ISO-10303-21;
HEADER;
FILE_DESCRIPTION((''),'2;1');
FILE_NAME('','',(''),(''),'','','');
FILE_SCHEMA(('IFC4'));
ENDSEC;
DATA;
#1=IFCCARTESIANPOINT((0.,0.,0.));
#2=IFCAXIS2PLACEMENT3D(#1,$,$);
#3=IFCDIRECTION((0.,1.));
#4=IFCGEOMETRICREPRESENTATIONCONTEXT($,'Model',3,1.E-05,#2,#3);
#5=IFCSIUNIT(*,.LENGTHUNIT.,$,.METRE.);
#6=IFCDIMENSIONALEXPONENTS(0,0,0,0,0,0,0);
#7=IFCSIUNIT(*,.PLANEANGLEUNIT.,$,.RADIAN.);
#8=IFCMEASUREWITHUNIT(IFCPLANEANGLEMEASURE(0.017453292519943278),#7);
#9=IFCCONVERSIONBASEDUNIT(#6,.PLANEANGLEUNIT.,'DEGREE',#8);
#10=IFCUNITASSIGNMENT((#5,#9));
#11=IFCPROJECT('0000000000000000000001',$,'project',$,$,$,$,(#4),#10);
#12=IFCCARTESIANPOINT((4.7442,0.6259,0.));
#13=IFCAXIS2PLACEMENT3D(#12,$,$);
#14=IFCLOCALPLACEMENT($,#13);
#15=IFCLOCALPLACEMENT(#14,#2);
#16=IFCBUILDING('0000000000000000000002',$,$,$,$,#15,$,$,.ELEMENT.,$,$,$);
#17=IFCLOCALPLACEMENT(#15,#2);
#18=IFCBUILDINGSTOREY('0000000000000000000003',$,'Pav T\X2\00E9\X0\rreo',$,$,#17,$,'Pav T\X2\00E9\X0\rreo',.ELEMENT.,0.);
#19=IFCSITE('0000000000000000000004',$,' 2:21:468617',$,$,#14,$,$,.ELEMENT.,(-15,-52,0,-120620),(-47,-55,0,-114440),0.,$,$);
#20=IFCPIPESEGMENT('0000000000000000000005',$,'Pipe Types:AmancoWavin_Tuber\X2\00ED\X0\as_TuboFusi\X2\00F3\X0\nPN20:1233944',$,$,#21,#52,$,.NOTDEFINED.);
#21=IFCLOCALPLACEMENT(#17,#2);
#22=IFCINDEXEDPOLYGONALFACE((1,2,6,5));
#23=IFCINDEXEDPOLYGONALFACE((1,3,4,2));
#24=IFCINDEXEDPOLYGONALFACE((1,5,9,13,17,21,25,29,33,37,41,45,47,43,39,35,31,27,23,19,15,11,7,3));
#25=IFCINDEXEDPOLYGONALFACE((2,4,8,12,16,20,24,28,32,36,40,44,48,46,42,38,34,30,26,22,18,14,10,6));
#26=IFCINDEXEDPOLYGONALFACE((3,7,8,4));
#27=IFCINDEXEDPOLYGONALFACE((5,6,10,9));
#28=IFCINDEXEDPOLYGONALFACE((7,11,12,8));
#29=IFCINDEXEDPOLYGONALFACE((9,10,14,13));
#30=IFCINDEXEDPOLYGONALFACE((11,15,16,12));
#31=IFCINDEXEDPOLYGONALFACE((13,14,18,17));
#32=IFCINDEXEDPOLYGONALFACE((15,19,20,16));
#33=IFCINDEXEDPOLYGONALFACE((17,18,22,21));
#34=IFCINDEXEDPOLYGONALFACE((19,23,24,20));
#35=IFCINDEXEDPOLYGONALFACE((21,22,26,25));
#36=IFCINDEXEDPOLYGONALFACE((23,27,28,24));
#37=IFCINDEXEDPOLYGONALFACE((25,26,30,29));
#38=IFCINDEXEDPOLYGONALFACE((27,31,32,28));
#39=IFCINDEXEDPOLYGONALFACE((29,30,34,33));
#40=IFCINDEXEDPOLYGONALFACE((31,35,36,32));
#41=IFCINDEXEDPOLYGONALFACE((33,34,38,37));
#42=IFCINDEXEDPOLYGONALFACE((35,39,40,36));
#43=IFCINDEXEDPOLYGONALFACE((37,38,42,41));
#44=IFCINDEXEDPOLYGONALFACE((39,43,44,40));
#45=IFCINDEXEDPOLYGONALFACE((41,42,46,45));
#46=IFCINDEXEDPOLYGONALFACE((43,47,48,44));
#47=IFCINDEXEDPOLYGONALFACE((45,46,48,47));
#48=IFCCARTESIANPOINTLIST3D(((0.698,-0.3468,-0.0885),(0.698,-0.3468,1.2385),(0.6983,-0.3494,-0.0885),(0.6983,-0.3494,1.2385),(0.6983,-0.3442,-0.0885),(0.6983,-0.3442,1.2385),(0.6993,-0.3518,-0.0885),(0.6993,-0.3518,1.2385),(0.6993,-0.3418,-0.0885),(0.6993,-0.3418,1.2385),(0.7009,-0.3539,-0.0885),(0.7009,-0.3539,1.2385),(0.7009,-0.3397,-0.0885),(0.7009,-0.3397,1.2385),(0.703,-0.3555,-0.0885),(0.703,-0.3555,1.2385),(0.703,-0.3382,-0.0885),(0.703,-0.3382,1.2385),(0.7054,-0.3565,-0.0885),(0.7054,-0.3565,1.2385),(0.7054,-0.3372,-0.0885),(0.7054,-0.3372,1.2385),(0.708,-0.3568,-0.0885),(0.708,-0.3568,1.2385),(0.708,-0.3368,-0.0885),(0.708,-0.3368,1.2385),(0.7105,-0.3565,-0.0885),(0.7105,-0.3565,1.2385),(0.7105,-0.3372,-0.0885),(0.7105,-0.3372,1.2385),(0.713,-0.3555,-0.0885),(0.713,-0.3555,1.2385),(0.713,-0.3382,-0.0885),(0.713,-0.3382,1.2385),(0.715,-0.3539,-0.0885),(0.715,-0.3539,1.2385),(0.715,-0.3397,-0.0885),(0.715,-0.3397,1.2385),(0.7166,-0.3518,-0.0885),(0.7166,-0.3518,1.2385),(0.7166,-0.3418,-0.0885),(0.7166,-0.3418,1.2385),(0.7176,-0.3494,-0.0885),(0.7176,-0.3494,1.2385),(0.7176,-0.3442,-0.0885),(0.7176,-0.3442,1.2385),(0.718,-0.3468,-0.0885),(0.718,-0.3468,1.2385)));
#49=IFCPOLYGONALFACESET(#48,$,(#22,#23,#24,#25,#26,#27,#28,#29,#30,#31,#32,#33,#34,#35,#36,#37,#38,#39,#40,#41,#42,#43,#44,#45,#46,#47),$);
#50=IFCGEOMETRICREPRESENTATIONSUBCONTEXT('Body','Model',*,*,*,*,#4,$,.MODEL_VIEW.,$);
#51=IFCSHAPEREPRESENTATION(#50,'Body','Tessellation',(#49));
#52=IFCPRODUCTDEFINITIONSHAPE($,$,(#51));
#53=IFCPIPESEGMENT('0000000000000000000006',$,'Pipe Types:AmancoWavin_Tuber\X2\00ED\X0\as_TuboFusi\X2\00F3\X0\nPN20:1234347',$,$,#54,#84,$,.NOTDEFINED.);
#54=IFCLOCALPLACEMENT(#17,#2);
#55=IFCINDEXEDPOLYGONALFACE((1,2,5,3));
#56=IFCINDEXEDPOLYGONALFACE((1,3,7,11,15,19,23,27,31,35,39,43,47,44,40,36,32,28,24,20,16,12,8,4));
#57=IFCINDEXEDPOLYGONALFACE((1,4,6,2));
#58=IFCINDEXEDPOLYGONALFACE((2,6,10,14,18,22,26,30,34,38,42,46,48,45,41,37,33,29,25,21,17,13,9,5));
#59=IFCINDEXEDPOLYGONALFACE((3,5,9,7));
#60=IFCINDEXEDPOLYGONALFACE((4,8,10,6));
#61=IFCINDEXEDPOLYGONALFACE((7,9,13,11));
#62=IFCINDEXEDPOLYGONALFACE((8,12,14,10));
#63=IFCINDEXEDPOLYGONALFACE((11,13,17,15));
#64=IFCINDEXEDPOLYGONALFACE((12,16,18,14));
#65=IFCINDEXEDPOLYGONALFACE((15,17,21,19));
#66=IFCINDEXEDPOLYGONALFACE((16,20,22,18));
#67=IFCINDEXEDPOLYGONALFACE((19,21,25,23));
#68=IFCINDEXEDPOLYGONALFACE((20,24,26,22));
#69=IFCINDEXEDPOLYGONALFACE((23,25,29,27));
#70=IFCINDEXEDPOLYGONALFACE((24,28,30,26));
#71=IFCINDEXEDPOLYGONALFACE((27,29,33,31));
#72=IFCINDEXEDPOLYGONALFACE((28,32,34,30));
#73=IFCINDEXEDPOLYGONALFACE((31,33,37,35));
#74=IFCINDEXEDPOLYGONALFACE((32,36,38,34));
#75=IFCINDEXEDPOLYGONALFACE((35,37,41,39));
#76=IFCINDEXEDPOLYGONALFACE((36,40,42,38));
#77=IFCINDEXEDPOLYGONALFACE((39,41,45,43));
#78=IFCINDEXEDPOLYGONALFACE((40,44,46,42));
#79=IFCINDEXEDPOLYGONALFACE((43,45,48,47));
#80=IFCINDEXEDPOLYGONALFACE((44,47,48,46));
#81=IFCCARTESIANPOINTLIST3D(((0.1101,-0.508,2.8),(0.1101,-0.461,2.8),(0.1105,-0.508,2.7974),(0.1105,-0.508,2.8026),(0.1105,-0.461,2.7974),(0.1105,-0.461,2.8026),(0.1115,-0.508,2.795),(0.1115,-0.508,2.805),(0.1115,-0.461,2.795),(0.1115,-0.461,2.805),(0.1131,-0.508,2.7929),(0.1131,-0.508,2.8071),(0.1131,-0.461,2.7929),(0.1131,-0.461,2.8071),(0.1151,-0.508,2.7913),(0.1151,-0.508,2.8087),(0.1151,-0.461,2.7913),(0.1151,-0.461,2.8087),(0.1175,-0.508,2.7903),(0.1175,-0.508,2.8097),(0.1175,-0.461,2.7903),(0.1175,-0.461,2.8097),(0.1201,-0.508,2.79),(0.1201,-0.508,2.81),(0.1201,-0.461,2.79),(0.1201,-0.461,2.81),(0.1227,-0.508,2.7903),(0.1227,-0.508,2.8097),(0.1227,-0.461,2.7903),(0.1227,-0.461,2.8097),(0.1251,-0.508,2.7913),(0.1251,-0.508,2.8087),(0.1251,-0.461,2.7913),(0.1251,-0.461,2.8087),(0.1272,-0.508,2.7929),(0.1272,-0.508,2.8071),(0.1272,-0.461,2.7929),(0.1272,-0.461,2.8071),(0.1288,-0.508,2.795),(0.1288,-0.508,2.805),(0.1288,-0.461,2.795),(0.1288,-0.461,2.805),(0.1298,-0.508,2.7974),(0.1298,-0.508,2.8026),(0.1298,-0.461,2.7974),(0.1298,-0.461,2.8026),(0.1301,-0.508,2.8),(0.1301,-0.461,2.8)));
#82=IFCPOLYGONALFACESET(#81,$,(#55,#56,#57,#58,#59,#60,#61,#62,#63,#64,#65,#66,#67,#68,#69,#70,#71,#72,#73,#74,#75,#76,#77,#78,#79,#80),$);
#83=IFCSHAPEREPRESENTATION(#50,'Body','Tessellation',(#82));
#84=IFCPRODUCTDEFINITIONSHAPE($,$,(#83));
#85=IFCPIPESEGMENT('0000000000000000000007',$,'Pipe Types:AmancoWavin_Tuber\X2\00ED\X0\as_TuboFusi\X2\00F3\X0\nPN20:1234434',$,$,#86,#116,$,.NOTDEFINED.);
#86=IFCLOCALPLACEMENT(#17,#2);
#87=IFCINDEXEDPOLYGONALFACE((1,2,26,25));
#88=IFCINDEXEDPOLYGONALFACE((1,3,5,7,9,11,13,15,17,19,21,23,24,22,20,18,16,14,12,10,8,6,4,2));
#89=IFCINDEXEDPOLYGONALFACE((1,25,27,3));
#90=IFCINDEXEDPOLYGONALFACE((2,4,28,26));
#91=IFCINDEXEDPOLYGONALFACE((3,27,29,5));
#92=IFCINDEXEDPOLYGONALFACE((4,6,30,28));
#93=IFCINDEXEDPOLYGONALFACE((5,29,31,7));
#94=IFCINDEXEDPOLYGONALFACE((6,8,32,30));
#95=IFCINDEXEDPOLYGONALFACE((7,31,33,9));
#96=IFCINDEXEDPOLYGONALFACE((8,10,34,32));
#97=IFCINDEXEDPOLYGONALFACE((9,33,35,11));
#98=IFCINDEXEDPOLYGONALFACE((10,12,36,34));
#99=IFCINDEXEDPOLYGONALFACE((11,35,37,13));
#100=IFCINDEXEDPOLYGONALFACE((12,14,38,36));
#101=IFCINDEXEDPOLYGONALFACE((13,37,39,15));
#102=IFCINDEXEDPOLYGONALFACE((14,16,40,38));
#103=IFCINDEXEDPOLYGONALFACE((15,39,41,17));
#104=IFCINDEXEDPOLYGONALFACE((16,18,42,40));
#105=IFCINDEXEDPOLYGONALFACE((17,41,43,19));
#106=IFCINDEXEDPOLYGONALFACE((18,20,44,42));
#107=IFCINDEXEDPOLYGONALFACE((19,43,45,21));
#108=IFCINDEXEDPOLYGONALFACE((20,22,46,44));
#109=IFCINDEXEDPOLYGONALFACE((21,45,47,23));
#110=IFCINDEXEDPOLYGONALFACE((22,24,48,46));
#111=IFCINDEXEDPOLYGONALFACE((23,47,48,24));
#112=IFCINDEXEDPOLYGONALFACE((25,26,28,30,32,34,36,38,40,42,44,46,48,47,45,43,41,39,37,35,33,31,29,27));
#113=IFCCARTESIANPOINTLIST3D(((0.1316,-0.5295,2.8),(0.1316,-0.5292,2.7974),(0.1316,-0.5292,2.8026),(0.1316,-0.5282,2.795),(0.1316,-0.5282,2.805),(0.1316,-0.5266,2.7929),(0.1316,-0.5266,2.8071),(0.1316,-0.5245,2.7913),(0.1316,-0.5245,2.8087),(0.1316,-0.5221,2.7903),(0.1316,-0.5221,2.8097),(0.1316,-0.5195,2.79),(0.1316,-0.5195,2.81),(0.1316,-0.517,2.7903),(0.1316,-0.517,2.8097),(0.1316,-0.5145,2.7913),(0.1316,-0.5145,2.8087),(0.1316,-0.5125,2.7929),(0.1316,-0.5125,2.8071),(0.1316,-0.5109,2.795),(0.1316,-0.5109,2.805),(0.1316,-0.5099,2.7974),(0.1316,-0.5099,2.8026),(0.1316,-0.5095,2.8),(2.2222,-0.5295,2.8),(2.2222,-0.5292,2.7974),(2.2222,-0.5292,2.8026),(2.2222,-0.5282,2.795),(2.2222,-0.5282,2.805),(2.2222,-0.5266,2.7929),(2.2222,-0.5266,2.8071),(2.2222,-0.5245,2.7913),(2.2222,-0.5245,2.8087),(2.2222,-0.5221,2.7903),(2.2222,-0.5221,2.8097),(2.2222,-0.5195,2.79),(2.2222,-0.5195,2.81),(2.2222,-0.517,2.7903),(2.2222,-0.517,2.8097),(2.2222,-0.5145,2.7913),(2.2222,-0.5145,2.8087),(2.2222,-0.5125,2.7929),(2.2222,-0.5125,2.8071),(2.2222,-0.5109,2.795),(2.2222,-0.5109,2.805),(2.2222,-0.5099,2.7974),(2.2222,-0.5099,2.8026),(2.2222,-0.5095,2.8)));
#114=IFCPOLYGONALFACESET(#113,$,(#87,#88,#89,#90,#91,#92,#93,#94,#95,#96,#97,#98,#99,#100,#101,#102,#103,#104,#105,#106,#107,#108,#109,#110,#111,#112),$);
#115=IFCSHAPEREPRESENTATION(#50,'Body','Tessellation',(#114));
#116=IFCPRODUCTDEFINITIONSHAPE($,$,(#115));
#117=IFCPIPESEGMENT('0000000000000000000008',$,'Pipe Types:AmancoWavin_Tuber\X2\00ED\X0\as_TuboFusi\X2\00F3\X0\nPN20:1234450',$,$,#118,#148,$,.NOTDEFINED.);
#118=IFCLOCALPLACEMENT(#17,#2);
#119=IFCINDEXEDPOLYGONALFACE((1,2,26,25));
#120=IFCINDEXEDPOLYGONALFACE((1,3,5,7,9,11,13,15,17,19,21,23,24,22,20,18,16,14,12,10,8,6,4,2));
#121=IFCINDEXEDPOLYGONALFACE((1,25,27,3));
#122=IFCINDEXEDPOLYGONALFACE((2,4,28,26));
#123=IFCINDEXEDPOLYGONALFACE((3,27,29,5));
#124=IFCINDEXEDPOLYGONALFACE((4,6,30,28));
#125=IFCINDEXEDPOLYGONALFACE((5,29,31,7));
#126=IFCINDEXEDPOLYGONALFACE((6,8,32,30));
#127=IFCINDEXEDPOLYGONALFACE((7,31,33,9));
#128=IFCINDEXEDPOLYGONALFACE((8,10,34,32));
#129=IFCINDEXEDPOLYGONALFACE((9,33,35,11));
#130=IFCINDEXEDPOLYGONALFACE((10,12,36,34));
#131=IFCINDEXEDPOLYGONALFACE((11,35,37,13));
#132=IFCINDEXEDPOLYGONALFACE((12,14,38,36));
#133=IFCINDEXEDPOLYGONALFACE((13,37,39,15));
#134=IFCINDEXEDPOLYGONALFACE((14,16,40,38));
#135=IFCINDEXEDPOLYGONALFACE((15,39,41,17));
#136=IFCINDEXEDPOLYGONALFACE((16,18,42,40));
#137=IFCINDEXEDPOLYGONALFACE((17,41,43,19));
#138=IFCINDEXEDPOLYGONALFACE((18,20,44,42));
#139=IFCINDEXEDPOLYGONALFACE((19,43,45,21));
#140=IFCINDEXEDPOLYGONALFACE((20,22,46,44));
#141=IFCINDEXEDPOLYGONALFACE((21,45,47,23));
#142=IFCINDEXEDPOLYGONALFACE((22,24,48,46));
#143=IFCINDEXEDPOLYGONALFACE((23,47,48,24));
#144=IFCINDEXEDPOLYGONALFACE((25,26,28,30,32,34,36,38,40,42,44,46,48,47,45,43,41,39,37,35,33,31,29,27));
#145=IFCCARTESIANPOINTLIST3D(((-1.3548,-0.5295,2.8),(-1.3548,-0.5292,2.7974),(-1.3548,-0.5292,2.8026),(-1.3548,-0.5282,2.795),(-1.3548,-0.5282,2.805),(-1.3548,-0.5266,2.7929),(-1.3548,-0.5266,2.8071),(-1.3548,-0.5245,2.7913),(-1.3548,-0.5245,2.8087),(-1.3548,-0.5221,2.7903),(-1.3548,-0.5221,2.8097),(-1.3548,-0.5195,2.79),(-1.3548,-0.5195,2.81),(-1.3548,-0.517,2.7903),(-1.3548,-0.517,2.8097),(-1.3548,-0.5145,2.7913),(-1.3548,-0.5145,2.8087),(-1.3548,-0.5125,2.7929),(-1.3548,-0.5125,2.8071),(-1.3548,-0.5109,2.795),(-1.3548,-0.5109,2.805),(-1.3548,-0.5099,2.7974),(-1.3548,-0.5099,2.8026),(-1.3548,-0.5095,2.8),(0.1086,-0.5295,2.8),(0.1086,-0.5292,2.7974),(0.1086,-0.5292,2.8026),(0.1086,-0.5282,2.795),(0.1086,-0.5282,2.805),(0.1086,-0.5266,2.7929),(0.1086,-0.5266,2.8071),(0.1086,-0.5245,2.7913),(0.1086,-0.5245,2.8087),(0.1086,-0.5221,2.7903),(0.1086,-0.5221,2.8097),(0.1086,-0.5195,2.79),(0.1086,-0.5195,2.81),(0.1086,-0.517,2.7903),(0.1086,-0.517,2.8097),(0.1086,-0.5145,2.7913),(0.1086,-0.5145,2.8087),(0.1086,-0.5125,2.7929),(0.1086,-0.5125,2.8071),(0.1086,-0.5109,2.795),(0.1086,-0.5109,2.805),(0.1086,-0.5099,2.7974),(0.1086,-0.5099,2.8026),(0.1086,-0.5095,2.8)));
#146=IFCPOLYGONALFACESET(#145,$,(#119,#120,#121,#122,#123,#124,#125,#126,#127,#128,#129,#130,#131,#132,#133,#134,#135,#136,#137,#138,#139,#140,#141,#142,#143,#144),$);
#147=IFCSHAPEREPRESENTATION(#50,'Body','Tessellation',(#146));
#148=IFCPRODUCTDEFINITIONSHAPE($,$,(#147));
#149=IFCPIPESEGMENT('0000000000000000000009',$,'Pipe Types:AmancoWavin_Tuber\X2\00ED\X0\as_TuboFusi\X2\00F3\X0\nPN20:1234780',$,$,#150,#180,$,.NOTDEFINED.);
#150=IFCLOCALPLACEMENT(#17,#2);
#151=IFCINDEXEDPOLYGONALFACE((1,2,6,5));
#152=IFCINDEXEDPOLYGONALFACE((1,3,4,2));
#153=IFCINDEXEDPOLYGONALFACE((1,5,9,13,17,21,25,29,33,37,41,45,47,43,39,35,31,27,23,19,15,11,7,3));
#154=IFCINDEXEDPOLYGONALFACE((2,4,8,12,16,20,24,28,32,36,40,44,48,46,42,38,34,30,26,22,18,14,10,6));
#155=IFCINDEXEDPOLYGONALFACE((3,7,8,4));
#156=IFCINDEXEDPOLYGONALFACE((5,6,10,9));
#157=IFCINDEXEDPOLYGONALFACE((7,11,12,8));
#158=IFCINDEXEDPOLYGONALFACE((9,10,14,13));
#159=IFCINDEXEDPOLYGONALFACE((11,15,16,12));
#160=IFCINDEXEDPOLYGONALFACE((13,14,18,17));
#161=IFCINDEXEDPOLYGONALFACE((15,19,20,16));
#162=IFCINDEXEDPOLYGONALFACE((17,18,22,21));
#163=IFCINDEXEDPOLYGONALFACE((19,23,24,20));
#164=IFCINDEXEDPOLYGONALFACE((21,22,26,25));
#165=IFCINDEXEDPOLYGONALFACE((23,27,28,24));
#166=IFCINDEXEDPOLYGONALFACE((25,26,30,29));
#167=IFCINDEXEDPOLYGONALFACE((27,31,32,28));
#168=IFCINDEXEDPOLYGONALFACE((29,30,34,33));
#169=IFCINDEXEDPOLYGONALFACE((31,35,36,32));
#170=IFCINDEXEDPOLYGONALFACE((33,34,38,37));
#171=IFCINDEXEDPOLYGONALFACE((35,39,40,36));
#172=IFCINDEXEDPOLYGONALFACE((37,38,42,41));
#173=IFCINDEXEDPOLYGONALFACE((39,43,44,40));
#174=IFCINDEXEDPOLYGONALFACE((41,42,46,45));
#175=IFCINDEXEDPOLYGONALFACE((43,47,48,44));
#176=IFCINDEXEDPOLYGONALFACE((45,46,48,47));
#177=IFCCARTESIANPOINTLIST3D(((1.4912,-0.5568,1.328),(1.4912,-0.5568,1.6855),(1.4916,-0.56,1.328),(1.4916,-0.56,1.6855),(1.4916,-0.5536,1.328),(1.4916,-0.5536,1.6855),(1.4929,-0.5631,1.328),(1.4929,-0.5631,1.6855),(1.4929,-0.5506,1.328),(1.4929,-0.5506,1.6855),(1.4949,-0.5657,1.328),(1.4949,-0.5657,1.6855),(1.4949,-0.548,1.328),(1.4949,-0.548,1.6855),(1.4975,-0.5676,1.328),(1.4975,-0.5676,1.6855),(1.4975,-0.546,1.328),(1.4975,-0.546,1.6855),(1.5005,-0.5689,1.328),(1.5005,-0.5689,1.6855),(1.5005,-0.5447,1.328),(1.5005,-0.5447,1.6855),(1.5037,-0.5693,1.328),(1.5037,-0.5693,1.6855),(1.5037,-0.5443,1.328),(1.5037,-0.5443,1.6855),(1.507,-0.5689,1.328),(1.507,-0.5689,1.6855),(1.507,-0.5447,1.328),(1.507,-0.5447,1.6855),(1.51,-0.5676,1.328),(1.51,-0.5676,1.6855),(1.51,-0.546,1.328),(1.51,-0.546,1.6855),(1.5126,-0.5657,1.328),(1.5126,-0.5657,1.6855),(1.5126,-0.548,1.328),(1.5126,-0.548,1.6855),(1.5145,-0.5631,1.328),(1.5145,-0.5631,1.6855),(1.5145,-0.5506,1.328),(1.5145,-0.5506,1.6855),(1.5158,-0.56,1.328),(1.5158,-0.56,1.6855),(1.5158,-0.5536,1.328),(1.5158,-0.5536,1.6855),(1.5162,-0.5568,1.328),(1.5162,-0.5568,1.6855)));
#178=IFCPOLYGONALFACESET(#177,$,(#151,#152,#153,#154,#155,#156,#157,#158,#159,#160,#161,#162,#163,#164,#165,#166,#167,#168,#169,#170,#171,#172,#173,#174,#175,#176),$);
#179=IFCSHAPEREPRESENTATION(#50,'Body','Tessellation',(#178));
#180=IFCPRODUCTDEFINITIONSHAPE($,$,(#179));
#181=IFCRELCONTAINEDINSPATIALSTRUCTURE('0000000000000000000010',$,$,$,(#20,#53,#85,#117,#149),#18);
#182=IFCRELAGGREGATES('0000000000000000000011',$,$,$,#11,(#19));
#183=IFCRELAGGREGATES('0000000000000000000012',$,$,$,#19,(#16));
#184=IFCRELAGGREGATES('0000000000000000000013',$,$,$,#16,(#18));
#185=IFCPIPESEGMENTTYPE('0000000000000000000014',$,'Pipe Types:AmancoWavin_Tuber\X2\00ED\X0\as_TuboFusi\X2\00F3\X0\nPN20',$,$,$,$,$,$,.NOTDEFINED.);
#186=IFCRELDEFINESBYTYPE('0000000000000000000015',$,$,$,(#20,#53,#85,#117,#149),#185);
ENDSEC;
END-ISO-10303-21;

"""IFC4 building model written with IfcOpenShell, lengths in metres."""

from ifc_helpers import new_model, entity, si_unit, converted_unit, direction, frame, origin, place, context, subcontext, project, spatial, arc, indexed_curve, outline, extrude, type_object, element, save


model = new_model("IFC4")

# Units and contexts
model_context = context("Model", 3, precision=1e-05, world=origin(), true_north=direction((0.0, 1.0)))
body_context = subcontext(model_context, "Body", "Model", "MODEL_VIEW")
ifc_project = project(units=[si_unit("LENGTHUNIT", "METRE"), converted_unit("PLANEANGLEUNIT", "DEGREE", entity("IfcPlaneAngleMeasure", 0.017453292519943278), si_unit("PLANEANGLEUNIT", "RADIAN"), dimensions=[0, 0, 0, 0, 0, 0, 0])], contexts=[model_context])

# Site, building, storey
site_placement = place(None, frame((4.7442, 0.6259, 0.0)))
site = spatial("IfcSite", under=ifc_project, at=site_placement, Name=" 2:21:468617", CompositionType="ELEMENT", RefLatitude=(-15, -52, 0, -120620), RefLongitude=(-47, -55, 0, -114440), RefElevation=0.0)
building_placement = place(site_placement, origin())
building = spatial("IfcBuilding", under=site, at=building_placement, CompositionType="ELEMENT")
storey_placement = place(building_placement, origin())
storey = spatial("IfcBuildingStorey", under=building, at=storey_placement, Name="Pav Térreo", LongName="Pav Térreo", CompositionType="ELEMENT", Elevation=0.0)

# Pipe segments
pipe_segment_type_1 = type_object("IfcPipeSegmentType", Name="Pipe Types:AmancoWavin_Tuberías_TuboFusiónPN20", PredefinedType="NOTDEFINED")
pipe_segment_1_placement = place(storey_placement, origin())
element("IfcPipeSegment", 1, at=pipe_segment_1_placement, inside=storey, type_object=pipe_segment_type_1, Name="Pipe Types:AmancoWavin_Tuberías_TuboFusiónPN20:1233944", PredefinedType="NOTDEFINED", context=body_context, shape_type="SweptSolid", body=[
    extrude(outline(indexed_curve([(0.01, 0.0), (0.0071, 0.0071), (0.0, 0.01), (-0.0071, 0.0071), (-0.01, 0.0), (-0.0071, -0.0071), (0.0, -0.01), (0.0071, -0.0071)], segments=[arc(1, 2, 3), arc(3, 4, 5), arc(5, 6, 7), arc(7, 8, 1)], self_intersect=False)), frame((0.708, -0.3468, -0.0885), z_axis=(0.0, 0.0, 1.0), x_axis=(-1.0, 0.0, 0.0)), (0.0, 0.0, 1.0), 1.327),
])
pipe_segment_2_placement = place(storey_placement, origin())
element("IfcPipeSegment", 2, at=pipe_segment_2_placement, inside=storey, type_object=pipe_segment_type_1, Name="Pipe Types:AmancoWavin_Tuberías_TuboFusiónPN20:1234347", PredefinedType="NOTDEFINED", context=body_context, shape_type="SweptSolid", body=[
    extrude(outline(indexed_curve([(0.01, 0.0), (0.0071, 0.0071), (0.0, 0.01), (-0.0071, 0.0071), (-0.01, 0.0), (-0.0071, -0.0071), (0.0, -0.01), (0.0071, -0.0071)], segments=[arc(1, 2, 3), arc(3, 4, 5), arc(5, 6, 7), arc(7, 8, 1)], self_intersect=False)), frame((0.1201, -0.508, 2.8), z_axis=(0.0, 1.0, 0.0), x_axis=(-1.0, 0.0, 0.0)), (0.0, 0.0, 1.0), 0.047),
])
pipe_segment_3_placement = place(storey_placement, origin())
element("IfcPipeSegment", 3, at=pipe_segment_3_placement, inside=storey, type_object=pipe_segment_type_1, Name="Pipe Types:AmancoWavin_Tuberías_TuboFusiónPN20:1234434", PredefinedType="NOTDEFINED", context=body_context, shape_type="SweptSolid", body=[
    extrude(outline(indexed_curve([(0.01, 0.0), (0.0071, 0.0071), (0.0, 0.01), (-0.0071, 0.0071), (-0.01, 0.0), (-0.0071, -0.0071), (0.0, -0.01), (0.0071, -0.0071)], segments=[arc(1, 2, 3), arc(3, 4, 5), arc(5, 6, 7), arc(7, 8, 1)], self_intersect=False)), frame((0.1316, -0.5195, 2.8), z_axis=(1.0, 0.0, 0.0), x_axis=(0.0, -1.0, 0.0)), (0.0, 0.0, 1.0), 2.0906),
])
pipe_segment_4_placement = place(storey_placement, origin())
element("IfcPipeSegment", 4, at=pipe_segment_4_placement, inside=storey, type_object=pipe_segment_type_1, Name="Pipe Types:AmancoWavin_Tuberías_TuboFusiónPN20:1234450", PredefinedType="NOTDEFINED", context=body_context, shape_type="SweptSolid", body=[
    extrude(outline(indexed_curve([(0.01, 0.0), (0.0071, 0.0071), (0.0, 0.01), (-0.0071, 0.0071), (-0.01, 0.0), (-0.0071, -0.0071), (0.0, -0.01), (0.0071, -0.0071)], segments=[arc(1, 2, 3), arc(3, 4, 5), arc(5, 6, 7), arc(7, 8, 1)], self_intersect=False)), frame((-1.3548, -0.5195, 2.8), z_axis=(1.0, 0.0, 0.0), x_axis=(0.0, -1.0, 0.0)), (0.0, 0.0, 1.0), 1.4634),
])
pipe_segment_5_placement = place(storey_placement, origin())
element("IfcPipeSegment", 5, at=pipe_segment_5_placement, inside=storey, type_object=pipe_segment_type_1, Name="Pipe Types:AmancoWavin_Tuberías_TuboFusiónPN20:1234780", PredefinedType="NOTDEFINED", context=body_context, shape_type="SweptSolid", body=[
    extrude(outline(indexed_curve([(0.0125, 0.0), (0.0088, 0.0088), (0.0, 0.0125), (-0.0088, 0.0088), (-0.0125, 0.0), (-0.0088, -0.0088), (0.0, -0.0125), (0.0088, -0.0088)], segments=[arc(1, 2, 3), arc(3, 4, 5), arc(5, 6, 7), arc(7, 8, 1)], self_intersect=False)), frame((1.5037, -0.5568, 1.328)), (0.0, 0.0, 1.0), 0.3575),
])

save(model, "model.ifc")
